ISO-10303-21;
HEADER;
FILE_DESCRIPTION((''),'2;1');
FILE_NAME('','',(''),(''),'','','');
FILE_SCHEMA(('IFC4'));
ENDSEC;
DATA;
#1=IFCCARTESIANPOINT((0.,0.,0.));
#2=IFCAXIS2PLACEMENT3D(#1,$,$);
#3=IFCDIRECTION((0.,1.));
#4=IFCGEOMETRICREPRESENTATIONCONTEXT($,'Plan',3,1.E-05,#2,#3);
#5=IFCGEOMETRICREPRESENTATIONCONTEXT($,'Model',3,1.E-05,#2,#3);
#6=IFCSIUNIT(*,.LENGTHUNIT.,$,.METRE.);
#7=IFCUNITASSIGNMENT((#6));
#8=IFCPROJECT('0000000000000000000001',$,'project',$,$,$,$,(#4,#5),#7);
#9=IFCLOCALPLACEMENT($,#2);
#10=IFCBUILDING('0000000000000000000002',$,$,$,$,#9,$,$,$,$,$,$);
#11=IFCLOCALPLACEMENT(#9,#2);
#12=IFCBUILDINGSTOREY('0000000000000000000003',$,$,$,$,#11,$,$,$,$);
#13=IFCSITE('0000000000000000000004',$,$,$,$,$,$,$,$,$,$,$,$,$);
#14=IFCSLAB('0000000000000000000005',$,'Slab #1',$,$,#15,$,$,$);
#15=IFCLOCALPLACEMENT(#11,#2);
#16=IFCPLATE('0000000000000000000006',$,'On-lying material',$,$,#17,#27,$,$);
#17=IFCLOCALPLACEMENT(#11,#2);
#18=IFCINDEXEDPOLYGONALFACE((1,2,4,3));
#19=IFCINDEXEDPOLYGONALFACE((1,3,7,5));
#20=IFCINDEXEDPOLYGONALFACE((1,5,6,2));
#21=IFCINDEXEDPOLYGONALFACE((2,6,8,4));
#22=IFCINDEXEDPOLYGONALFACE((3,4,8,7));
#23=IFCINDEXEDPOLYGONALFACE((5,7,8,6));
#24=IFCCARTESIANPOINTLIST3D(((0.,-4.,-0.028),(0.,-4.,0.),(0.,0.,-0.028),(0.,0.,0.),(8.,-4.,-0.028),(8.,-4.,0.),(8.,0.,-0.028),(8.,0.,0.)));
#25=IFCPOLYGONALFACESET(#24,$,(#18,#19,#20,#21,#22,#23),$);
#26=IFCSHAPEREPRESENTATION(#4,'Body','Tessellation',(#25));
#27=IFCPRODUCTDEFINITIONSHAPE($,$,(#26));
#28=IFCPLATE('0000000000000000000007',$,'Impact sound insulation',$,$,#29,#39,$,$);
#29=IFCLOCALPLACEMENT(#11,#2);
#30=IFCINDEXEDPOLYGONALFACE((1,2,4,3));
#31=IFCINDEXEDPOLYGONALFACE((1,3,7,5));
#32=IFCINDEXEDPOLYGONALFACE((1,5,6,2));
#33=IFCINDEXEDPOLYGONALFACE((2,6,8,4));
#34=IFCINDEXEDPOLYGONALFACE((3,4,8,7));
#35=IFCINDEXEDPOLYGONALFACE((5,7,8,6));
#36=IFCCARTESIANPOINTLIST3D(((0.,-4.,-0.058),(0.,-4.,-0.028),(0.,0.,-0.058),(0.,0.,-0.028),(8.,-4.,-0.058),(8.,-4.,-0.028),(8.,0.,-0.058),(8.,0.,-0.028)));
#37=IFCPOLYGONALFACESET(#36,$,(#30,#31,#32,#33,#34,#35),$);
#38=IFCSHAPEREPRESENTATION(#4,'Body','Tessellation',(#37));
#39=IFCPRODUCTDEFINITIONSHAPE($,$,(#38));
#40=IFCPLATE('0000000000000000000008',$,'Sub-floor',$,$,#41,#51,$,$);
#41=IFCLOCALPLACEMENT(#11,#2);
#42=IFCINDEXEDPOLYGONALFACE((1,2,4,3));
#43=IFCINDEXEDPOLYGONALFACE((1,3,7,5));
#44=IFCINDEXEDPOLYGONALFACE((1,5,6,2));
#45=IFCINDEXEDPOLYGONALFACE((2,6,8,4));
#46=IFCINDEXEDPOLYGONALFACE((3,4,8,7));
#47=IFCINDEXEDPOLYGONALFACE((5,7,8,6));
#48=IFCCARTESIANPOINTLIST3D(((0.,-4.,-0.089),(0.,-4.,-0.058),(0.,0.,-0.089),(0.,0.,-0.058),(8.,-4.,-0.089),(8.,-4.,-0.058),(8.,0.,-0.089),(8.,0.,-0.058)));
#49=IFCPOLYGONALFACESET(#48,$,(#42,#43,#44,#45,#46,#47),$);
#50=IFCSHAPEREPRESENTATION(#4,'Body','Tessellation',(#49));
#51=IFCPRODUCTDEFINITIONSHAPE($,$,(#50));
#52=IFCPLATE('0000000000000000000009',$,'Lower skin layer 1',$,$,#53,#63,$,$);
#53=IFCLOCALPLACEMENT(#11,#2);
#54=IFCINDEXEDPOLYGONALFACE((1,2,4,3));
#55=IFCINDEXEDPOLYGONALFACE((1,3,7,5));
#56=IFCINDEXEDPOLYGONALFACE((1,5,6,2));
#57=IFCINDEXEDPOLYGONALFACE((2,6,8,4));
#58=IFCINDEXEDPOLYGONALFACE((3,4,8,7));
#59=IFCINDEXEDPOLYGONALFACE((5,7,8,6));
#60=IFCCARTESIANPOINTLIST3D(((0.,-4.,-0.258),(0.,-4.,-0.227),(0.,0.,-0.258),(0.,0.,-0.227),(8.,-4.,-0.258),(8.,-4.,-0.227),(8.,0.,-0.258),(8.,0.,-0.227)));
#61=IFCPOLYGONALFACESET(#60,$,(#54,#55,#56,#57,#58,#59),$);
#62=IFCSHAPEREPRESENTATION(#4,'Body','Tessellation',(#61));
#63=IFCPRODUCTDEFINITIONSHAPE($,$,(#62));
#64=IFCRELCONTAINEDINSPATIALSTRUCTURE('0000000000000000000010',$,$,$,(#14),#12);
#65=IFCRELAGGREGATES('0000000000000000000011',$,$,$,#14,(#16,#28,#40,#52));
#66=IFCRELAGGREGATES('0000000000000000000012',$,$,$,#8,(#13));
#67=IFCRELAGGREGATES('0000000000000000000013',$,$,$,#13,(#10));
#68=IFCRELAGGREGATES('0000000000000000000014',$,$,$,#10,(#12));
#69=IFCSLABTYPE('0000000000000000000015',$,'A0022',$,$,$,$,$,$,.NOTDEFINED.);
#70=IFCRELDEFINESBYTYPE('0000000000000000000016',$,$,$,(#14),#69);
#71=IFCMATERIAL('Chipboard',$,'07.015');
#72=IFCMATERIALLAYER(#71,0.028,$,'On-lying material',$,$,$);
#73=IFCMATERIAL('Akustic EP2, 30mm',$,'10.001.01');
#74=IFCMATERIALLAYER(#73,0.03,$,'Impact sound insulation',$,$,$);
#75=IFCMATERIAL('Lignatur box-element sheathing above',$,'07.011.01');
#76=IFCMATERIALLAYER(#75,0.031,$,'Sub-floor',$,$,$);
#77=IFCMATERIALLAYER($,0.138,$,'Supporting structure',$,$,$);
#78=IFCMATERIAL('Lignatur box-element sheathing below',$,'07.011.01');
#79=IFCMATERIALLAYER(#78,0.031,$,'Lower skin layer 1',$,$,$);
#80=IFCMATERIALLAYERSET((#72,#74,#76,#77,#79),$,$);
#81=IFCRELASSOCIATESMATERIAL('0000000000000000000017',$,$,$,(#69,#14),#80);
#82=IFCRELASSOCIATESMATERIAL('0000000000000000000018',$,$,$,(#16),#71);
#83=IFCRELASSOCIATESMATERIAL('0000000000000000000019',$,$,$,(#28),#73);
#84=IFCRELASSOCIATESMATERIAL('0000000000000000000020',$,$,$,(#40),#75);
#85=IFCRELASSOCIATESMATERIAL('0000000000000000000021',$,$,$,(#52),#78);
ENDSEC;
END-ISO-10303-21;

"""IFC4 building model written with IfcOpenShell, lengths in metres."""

from ifc_helpers import new_model, si_unit, direction, frame, frame_2d, origin, origin_with_axes, place, context, project, spatial, rectangle, extrude, material, layer, layer_set, type_object, element, aggregate, save


model = new_model("IFC4")

# Units and contexts
plan_context = context("Plan", 3, precision=1e-05, world=origin(), true_north=direction((0.0, 1.0)))
model_context = context("Model", 3, precision=1e-05, world=origin(), true_north=direction((0.0, 1.0)))
ifc_project = project(units=[si_unit("LENGTHUNIT", "METRE")], contexts=[plan_context, model_context])

# Site, building, storey
site = spatial("IfcSite", under=ifc_project)
building_placement = place(None, origin())
building = spatial("IfcBuilding", under=site, at=building_placement)
storey_placement = place(building_placement, origin())
storey = spatial("IfcBuildingStorey", under=building, at=storey_placement)

# Slab, plates
ifc_material_1 = material(Name="Chipboard", Category="07.015")
ifc_layer_1 = layer(ifc_material_1, 0.028, Name="On-lying material")
ifc_material_2 = material(Name="Akustic EP2, 30mm", Category="10.001.01")
ifc_layer_2 = layer(ifc_material_2, 0.03, Name="Impact sound insulation")
ifc_material_3 = material(Name="Lignatur box-element sheathing above", Category="07.011.01")
ifc_layer_3 = layer(ifc_material_3, 0.031, Name="Sub-floor")
ifc_layer_4 = layer(None, 0.138, Name="Supporting structure")
ifc_material_4 = material(Name="Lignatur box-element sheathing below", Category="07.011.01")
ifc_layer_5 = layer(ifc_material_4, 0.031, Name="Lower skin layer 1")
ifc_layer_set = layer_set([ifc_layer_1, ifc_layer_2, ifc_layer_3, ifc_layer_4, ifc_layer_5])
slab_type = type_object("IfcSlabType", Name="A0022", PredefinedType="NOTDEFINED", material=ifc_layer_set)
slab_placement = place(None, frame((0.0, 0.0, 0.0), z_axis=(0.0, 0.0, -1.0), x_axis=(1.0, 0.0, 0.0)))
slab = element("IfcSlab", 1, at=slab_placement, inside=storey, type_object=slab_type, material=ifc_layer_set, Name="Slab #1")
plate_1_placement = place(slab_placement, origin())
plate_1 = element("IfcPlate", 2, at=plate_1_placement, material=ifc_material_1, Name="On-lying material", context=plan_context, shape_type="SweptSolid", body=[
    extrude(rectangle(XDim=8.0, YDim=4.0, at=frame_2d((4.0, 2.0), x_axis=(1.0, 0.0))), origin_with_axes(), (0.0, 0.0, 1.0), 0.028),
])
plate_2_placement = place(slab_placement, origin())
plate_2 = element("IfcPlate", 3, at=plate_2_placement, material=ifc_material_2, Name="Impact sound insulation", context=plan_context, shape_type="SweptSolid", body=[
    extrude(rectangle(XDim=8.0, YDim=4.0, at=frame_2d((4.0, 2.0), x_axis=(1.0, 0.0))), frame((0.0, 0.0, 0.028), z_axis=(0.0, 0.0, 1.0), x_axis=(1.0, 0.0, 0.0)), (0.0, 0.0, 1.0), 0.03),
])
plate_3_placement = place(slab_placement, origin())
plate_3 = element("IfcPlate", 4, at=plate_3_placement, material=ifc_material_3, Name="Sub-floor", context=plan_context, shape_type="SweptSolid", body=[
    extrude(rectangle(XDim=8.0, YDim=4.0, at=frame_2d((4.0, 2.0), x_axis=(1.0, 0.0))), frame((0.0, 0.0, 0.058), z_axis=(0.0, 0.0, 1.0), x_axis=(1.0, 0.0, 0.0)), (0.0, 0.0, 1.0), 0.031),
])
plate_4_placement = place(slab_placement, origin())
plate_4 = element("IfcPlate", 5, at=plate_4_placement, material=ifc_material_4, Name="Lower skin layer 1", context=plan_context, shape_type="SweptSolid", body=[
    extrude(rectangle(XDim=8.0, YDim=4.0, at=frame_2d((4.0, 2.0), x_axis=(1.0, 0.0))), frame((0.0, 0.0, 0.227), z_axis=(0.0, 0.0, 1.0), x_axis=(1.0, 0.0, 0.0)), (0.0, 0.0, 1.0), 0.031),
])
aggregate(slab, [plate_1, plate_2, plate_3, plate_4])

save(model, "model.ifc")
